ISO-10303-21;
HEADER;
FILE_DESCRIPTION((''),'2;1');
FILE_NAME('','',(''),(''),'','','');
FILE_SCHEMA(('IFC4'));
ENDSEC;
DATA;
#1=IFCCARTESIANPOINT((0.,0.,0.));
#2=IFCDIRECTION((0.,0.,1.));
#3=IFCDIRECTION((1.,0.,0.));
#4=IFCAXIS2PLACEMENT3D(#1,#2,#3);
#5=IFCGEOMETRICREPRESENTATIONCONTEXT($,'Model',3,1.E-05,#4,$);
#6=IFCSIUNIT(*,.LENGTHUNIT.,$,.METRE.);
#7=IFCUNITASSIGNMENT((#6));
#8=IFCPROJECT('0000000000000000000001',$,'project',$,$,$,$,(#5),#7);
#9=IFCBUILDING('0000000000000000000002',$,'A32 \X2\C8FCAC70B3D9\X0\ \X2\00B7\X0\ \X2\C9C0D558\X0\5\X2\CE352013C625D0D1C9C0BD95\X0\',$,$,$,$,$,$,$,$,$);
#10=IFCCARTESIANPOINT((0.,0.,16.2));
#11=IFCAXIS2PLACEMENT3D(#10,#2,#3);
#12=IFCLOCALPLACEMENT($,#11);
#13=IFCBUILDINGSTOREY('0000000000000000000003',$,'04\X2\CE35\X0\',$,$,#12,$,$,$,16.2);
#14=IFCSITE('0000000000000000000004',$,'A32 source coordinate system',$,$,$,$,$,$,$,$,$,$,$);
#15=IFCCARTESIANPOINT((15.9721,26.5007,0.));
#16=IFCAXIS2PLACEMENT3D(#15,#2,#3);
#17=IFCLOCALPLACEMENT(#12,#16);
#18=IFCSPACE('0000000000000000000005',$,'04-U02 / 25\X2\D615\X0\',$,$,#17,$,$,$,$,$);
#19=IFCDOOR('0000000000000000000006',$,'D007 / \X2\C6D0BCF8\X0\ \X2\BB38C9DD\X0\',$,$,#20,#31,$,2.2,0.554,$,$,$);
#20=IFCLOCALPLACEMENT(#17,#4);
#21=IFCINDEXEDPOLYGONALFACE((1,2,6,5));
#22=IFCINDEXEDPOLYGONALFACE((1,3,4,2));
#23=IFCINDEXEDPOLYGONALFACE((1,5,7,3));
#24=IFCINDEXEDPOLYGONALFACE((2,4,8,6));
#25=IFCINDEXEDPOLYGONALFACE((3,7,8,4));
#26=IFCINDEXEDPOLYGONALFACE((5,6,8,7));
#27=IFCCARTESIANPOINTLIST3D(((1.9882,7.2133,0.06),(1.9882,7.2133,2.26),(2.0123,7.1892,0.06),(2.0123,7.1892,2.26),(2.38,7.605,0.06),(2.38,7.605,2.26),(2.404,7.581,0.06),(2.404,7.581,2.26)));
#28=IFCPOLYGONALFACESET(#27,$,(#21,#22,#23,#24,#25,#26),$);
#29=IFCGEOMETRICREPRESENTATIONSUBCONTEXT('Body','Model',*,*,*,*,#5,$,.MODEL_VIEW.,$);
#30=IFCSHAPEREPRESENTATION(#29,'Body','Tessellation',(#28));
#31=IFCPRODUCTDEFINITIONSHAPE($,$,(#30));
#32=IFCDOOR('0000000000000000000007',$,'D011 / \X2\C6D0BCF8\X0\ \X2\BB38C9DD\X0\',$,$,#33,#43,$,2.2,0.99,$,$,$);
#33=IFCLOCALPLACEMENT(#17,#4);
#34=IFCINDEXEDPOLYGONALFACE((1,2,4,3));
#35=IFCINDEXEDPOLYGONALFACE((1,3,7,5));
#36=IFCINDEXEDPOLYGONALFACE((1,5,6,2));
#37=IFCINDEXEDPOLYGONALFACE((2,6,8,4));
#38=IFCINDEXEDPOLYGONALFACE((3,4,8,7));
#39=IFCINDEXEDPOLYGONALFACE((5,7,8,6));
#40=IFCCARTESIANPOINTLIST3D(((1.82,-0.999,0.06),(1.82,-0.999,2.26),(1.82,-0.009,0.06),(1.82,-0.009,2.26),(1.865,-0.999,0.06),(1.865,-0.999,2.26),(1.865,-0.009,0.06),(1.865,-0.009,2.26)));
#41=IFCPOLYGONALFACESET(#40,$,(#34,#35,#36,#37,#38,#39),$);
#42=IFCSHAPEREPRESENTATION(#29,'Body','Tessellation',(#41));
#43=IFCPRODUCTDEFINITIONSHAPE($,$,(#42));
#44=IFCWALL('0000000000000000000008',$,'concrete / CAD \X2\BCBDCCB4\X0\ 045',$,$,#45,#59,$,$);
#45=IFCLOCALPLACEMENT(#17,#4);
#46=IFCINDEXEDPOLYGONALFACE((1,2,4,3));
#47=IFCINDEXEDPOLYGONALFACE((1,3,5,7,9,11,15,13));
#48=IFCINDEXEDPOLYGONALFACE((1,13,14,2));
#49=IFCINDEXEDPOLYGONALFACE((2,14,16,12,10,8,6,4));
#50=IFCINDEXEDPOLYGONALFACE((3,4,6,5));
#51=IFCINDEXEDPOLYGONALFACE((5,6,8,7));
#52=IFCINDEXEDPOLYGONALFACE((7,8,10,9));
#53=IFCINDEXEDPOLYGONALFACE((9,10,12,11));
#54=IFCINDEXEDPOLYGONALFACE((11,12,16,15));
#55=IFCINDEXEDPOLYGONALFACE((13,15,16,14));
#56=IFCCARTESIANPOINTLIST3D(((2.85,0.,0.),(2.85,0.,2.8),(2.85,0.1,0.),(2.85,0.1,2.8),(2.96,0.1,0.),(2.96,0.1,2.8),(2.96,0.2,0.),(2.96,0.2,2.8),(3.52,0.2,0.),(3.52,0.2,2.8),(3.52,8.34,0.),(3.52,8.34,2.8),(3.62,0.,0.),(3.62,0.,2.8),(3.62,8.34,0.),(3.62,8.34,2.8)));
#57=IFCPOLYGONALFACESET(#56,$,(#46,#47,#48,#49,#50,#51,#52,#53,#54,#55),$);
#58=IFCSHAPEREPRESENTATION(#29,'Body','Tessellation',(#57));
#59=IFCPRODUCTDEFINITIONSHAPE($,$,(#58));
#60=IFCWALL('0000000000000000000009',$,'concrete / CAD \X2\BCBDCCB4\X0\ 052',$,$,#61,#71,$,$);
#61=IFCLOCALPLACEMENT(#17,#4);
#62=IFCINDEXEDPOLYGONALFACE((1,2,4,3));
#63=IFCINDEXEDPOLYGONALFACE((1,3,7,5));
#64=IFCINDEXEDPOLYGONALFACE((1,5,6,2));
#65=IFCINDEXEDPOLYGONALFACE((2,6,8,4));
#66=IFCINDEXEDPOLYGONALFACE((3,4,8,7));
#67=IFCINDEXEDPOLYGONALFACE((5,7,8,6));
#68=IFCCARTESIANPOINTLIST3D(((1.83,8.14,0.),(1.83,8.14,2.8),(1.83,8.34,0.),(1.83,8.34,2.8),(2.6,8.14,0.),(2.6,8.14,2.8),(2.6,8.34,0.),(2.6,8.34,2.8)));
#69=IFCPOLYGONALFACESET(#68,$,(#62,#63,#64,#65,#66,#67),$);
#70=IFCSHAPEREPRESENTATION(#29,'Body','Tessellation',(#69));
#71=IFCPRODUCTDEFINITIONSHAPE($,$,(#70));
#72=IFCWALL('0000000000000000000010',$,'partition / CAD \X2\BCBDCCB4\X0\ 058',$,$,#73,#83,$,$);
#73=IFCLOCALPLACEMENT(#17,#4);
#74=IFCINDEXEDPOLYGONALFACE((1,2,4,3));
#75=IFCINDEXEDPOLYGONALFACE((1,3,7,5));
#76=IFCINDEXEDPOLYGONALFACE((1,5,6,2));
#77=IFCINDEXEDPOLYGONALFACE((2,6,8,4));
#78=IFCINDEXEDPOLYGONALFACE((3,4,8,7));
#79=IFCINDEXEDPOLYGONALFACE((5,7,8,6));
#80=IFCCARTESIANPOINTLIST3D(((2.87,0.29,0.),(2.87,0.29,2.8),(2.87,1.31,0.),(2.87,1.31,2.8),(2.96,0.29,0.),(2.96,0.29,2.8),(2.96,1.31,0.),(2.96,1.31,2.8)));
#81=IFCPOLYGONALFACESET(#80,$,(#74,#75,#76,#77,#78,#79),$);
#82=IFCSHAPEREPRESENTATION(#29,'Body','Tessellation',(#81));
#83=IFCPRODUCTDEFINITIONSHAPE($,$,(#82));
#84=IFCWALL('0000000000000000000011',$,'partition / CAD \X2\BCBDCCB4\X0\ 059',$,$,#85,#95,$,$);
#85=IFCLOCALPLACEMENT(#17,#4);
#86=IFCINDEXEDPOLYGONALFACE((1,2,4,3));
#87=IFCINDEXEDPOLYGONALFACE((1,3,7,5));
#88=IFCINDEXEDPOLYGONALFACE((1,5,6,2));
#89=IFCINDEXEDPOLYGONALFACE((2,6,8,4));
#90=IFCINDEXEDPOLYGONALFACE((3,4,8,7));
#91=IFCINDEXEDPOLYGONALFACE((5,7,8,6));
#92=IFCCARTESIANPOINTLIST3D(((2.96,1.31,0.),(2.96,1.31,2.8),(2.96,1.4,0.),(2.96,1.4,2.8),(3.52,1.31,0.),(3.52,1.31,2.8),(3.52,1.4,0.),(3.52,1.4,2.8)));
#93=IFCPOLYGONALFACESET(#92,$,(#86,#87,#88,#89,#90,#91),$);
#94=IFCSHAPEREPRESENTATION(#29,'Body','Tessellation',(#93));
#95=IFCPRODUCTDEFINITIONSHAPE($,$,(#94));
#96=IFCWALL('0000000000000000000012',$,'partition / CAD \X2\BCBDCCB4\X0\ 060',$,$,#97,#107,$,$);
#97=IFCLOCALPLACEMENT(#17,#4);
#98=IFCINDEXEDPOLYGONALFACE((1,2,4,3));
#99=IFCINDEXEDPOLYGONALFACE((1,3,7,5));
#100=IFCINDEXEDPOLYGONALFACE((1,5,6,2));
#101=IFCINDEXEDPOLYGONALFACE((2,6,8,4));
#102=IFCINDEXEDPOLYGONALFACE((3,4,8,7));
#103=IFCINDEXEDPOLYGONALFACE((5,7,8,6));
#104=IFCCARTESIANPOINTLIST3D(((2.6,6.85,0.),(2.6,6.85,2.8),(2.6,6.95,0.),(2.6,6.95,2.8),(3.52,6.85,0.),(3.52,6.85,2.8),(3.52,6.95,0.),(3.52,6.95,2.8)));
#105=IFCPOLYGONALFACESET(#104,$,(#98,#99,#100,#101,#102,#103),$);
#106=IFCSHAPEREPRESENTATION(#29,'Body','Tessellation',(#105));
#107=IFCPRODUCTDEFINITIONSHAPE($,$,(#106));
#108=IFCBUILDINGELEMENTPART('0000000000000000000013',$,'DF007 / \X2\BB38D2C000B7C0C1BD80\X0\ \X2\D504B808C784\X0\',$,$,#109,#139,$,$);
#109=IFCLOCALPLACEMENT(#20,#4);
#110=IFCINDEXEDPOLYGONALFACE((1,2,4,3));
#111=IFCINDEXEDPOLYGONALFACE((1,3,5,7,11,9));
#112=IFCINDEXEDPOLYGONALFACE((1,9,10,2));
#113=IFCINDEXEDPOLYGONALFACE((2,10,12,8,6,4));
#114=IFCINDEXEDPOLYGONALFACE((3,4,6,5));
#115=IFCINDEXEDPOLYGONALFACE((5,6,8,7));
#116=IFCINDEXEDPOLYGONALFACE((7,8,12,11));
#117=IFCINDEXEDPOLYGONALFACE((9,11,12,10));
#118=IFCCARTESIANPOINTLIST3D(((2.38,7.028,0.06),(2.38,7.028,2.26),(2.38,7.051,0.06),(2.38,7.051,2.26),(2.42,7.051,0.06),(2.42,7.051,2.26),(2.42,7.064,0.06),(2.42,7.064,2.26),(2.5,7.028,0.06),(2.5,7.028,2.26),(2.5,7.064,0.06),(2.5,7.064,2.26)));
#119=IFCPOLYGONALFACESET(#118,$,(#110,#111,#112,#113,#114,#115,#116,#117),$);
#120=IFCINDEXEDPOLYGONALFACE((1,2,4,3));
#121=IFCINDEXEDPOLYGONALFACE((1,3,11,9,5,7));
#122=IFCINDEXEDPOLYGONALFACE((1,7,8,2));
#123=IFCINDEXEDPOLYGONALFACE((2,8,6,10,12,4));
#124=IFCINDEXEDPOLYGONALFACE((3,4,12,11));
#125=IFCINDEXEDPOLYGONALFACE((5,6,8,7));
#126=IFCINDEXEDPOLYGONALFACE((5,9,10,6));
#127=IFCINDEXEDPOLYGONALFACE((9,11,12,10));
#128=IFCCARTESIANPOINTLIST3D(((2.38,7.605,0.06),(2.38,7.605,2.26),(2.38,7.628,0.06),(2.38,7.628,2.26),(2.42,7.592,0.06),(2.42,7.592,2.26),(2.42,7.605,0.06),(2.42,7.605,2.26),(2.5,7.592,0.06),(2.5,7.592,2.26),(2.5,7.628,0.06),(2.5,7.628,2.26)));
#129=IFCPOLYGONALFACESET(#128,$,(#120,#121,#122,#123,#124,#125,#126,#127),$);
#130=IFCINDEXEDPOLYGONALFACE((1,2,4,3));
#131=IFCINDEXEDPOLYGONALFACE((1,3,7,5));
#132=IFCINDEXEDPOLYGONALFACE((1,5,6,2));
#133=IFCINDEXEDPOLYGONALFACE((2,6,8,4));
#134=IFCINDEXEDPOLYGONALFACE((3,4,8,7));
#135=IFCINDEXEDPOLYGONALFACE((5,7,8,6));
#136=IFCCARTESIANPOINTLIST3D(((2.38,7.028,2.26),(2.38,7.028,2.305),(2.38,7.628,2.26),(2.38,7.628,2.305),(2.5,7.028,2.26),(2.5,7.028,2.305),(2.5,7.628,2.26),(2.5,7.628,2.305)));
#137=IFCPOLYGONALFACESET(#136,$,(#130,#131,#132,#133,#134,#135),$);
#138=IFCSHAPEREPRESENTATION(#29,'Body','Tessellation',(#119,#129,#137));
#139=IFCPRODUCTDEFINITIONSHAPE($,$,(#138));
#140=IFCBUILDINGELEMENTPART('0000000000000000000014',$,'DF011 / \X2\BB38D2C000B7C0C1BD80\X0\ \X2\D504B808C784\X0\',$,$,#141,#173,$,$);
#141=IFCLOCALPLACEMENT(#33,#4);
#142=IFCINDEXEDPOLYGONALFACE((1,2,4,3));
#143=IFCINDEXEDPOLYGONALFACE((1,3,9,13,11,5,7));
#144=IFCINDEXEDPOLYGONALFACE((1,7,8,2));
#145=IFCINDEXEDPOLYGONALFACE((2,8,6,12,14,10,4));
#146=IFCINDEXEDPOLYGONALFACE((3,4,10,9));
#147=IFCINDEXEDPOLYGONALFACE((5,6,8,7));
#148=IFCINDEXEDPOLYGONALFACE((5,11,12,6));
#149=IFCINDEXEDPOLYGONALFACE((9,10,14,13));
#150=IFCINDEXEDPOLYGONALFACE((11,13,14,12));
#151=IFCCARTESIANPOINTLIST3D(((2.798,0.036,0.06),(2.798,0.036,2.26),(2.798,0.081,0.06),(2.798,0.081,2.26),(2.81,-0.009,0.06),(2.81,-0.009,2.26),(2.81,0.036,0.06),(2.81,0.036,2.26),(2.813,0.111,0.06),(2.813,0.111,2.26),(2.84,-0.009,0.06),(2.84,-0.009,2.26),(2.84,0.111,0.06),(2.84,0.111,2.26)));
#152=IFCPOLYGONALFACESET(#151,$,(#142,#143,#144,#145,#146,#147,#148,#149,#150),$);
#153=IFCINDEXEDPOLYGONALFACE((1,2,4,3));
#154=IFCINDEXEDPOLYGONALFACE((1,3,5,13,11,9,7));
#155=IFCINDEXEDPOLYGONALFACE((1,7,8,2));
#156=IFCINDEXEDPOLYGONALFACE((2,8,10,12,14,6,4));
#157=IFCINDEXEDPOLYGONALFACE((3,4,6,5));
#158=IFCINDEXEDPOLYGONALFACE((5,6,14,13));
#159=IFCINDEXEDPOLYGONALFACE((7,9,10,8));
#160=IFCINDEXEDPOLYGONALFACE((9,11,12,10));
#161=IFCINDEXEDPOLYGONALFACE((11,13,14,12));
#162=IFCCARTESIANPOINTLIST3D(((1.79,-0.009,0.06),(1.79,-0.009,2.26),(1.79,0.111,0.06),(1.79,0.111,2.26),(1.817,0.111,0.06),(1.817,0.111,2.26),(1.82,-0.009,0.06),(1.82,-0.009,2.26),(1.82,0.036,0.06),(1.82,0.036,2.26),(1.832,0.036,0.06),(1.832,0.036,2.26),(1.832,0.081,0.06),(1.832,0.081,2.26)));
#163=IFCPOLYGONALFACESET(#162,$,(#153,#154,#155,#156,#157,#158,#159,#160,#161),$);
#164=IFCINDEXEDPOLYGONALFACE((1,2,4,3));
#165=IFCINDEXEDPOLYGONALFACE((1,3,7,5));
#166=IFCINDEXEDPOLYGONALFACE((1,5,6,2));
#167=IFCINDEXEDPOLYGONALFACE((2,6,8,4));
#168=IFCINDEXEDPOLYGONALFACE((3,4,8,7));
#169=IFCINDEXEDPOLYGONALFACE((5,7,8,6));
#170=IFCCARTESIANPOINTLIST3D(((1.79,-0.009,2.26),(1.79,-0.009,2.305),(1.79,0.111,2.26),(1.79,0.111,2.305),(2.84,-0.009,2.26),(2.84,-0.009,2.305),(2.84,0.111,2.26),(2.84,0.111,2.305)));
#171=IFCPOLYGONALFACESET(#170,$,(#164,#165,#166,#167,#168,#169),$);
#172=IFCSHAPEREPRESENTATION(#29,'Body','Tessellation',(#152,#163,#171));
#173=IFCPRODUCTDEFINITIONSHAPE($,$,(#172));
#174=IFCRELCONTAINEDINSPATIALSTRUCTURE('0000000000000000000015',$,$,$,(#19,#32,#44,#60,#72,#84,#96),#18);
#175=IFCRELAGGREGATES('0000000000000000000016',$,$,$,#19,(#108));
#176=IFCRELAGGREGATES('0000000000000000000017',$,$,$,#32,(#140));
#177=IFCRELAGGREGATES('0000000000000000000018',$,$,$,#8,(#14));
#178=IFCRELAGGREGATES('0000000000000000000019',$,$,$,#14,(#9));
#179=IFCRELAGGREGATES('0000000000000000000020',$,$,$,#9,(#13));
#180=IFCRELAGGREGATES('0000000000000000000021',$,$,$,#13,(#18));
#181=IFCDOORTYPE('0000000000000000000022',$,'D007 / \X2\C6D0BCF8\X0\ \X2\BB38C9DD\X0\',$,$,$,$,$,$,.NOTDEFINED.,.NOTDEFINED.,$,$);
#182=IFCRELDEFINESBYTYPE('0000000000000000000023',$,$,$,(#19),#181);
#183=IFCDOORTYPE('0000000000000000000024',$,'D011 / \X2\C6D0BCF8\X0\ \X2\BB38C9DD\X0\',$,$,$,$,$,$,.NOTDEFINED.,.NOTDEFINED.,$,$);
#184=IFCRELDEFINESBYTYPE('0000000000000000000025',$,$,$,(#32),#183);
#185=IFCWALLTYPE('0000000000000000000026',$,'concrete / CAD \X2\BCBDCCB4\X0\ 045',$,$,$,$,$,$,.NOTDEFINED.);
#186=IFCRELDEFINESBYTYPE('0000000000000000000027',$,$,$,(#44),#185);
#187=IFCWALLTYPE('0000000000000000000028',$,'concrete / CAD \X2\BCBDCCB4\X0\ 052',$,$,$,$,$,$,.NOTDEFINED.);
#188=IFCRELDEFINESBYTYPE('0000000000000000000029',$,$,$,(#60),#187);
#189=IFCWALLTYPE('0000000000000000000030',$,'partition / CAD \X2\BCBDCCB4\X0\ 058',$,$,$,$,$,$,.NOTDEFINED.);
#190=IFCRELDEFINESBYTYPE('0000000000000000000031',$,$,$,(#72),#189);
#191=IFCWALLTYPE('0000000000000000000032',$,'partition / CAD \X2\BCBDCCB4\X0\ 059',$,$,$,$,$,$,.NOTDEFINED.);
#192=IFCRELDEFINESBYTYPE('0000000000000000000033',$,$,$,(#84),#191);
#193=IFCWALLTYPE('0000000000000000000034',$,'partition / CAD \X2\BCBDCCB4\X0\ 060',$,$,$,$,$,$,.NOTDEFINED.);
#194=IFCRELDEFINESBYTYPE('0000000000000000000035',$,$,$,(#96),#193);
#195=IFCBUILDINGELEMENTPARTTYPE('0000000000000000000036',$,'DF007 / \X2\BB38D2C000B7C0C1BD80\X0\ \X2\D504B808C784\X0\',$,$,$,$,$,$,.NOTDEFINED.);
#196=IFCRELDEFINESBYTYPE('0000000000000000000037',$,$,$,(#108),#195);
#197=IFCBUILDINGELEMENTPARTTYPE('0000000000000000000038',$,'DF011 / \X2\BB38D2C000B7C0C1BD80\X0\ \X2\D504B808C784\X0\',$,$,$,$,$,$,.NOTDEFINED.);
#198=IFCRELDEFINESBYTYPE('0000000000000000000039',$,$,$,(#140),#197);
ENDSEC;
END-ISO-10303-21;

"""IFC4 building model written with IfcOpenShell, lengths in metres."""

from ifc_helpers import new_model, si_unit, frame, origin, origin_with_axes, place, context, subcontext, project, spatial, polyline, outline, extrude, source, transform, mapped, type_object, type_shapes, element, aggregate, save


model = new_model("IFC4")

# Units and contexts
model_context = context("Model", 3, precision=1e-05, world=origin_with_axes())
body_context = subcontext(model_context, "Body", "Model", "MODEL_VIEW")
ifc_project = project(units=[si_unit("LENGTHUNIT", "METRE")], contexts=[model_context])

# Site, building, storey, space
storey_placement = place(None, frame((0.0, 0.0, 16.2), z_axis=(0.0, 0.0, 1.0), x_axis=(1.0, 0.0, 0.0)))
space_placement = place(storey_placement, frame((15.9721, 26.5007, 0.0), z_axis=(0.0, 0.0, 1.0), x_axis=(1.0, 0.0, 0.0)))
site = spatial("IfcSite", under=ifc_project, Name="A32 source coordinate system")
building = spatial("IfcBuilding", under=site, Name="A32 주거동 · 지하5층–옥탑지붕")
storey = spatial("IfcBuildingStorey", under=building, at=storey_placement, Name="04층", Elevation=16.2)
space = spatial("IfcSpace", under=storey, at=space_placement, Name="04-U02 / 25형")

# Doors
door_type_1 = type_object("IfcDoorType", Name="D007 / 원본 문짝", OperationType="NOTDEFINED", PredefinedType="NOTDEFINED")
shared_shape_1 = source(origin(), body_context, "Body", "SweptSolid", [
    extrude(outline(polyline([(2.0123, 7.1892), (1.9882, 7.2133), (2.38, 7.605), (2.404, 7.581), (2.0123, 7.1892)])), frame((0.0, 0.0, 0.06)), (0.0, 0.0, 1.0), 2.2),
])
type_shapes(door_type_1, [shared_shape_1])
door_1_placement = place(space_placement, origin_with_axes())
door_1 = element("IfcDoor", 1, at=door_1_placement, inside=space, type_object=door_type_1, Name="D007 / 원본 문짝", OverallHeight=2.2, OverallWidth=0.554, context=body_context, shape_type="MappedRepresentation", body=[
    mapped(shared_shape_1, transform((0.0, 0.0, 0.0), scale=1.0)),
])
door_type_2 = type_object("IfcDoorType", Name="D011 / 원본 문짝", OperationType="NOTDEFINED", PredefinedType="NOTDEFINED")
shared_shape_2 = source(origin(), body_context, "Body", "SweptSolid", [
    extrude(outline(polyline([(1.865, -0.999), (1.82, -0.999), (1.82, -0.009), (1.865, -0.009), (1.865, -0.999)])), frame((0.0, 0.0, 0.06)), (0.0, 0.0, 1.0), 2.2),
])
type_shapes(door_type_2, [shared_shape_2])
door_2_placement = place(space_placement, origin_with_axes())
door_2 = element("IfcDoor", 2, at=door_2_placement, inside=space, type_object=door_type_2, Name="D011 / 원본 문짝", OverallHeight=2.2, OverallWidth=0.99, context=body_context, shape_type="MappedRepresentation", body=[
    mapped(shared_shape_2, transform((0.0, 0.0, 0.0), scale=1.0)),
])

# Walls
wall_type_1 = type_object("IfcWallType", Name="concrete / CAD 벽체 045", PredefinedType="NOTDEFINED")
shared_shape_3 = source(origin(), body_context, "Body", "SweptSolid", [
    extrude(outline(polyline([(2.96, 0.1), (2.96, 0.2), (3.52, 0.2), (3.52, 8.34), (3.72, 8.34), (3.72, 8.34), (3.62, 8.34), (3.62, 0.0), (2.85, 0.0), (2.85, 0.1), (2.96, 0.1)])), origin(), (0.0, 0.0, 1.0), 2.8),
])
type_shapes(wall_type_1, [shared_shape_3])
wall_1_placement = place(space_placement, origin_with_axes())
element("IfcWall", 3, at=wall_1_placement, inside=space, type_object=wall_type_1, Name="concrete / CAD 벽체 045", context=body_context, shape_type="MappedRepresentation", body=[
    mapped(shared_shape_3, transform((0.0, 0.0, 0.0), scale=1.0)),
])
wall_type_2 = type_object("IfcWallType", Name="concrete / CAD 벽체 052", PredefinedType="NOTDEFINED")
shared_shape_4 = source(origin(), body_context, "Body", "SweptSolid", [
    extrude(outline(polyline([(2.6, 8.14), (1.83, 8.14), (1.83, 8.34), (2.6, 8.34), (2.6, 8.14)])), origin(), (0.0, 0.0, 1.0), 2.8),
])
type_shapes(wall_type_2, [shared_shape_4])
wall_2_placement = place(space_placement, origin_with_axes())
element("IfcWall", 4, at=wall_2_placement, inside=space, type_object=wall_type_2, Name="concrete / CAD 벽체 052", context=body_context, shape_type="MappedRepresentation", body=[
    mapped(shared_shape_4, transform((0.0, 0.0, 0.0), scale=1.0)),
])
wall_type_3 = type_object("IfcWallType", Name="partition / CAD 벽체 058", PredefinedType="NOTDEFINED")
shared_shape_5 = source(origin(), body_context, "Body", "SweptSolid", [
    extrude(outline(polyline([(2.96, 1.31), (2.96, 0.29), (2.87, 0.29), (2.87, 1.31), (2.96, 1.31)])), origin(), (0.0, 0.0, 1.0), 2.8),
])
type_shapes(wall_type_3, [shared_shape_5])
wall_3_placement = place(space_placement, origin_with_axes())
element("IfcWall", 5, at=wall_3_placement, inside=space, type_object=wall_type_3, Name="partition / CAD 벽체 058", context=body_context, shape_type="MappedRepresentation", body=[
    mapped(shared_shape_5, transform((0.0, 0.0, 0.0), scale=1.0)),
])
wall_type_4 = type_object("IfcWallType", Name="partition / CAD 벽체 059", PredefinedType="NOTDEFINED")
shared_shape_6 = source(origin(), body_context, "Body", "SweptSolid", [
    extrude(outline(polyline([(3.52, 1.31), (2.96, 1.31), (2.96, 1.4), (3.52, 1.4), (3.52, 1.31)])), origin(), (0.0, 0.0, 1.0), 2.8),
])
type_shapes(wall_type_4, [shared_shape_6])
wall_4_placement = place(space_placement, origin_with_axes())
element("IfcWall", 6, at=wall_4_placement, inside=space, type_object=wall_type_4, Name="partition / CAD 벽체 059", context=body_context, shape_type="MappedRepresentation", body=[
    mapped(shared_shape_6, transform((0.0, 0.0, 0.0), scale=1.0)),
])
wall_type_5 = type_object("IfcWallType", Name="partition / CAD 벽체 060", PredefinedType="NOTDEFINED")
shared_shape_7 = source(origin(), body_context, "Body", "SweptSolid", [
    extrude(outline(polyline([(3.52, 6.85), (2.6, 6.85), (2.6, 6.95), (3.52, 6.95), (3.52, 6.85)])), origin(), (0.0, 0.0, 1.0), 2.8),
])
type_shapes(wall_type_5, [shared_shape_7])
wall_5_placement = place(space_placement, origin_with_axes())
element("IfcWall", 7, at=wall_5_placement, inside=space, type_object=wall_type_5, Name="partition / CAD 벽체 060", context=body_context, shape_type="MappedRepresentation", body=[
    mapped(shared_shape_7, transform((0.0, 0.0, 0.0), scale=1.0)),
])

# Building element parts
building_element_part_type_1 = type_object("IfcBuildingElementPartType", Name="DF007 / 문틀·상부 프레임", PredefinedType="NOTDEFINED")
shared_shape_8 = source(origin(), body_context, "Body", "SweptSolid", [
    extrude(outline(polyline([(2.38, 7.028), (2.38, 7.051), (2.42, 7.051), (2.42, 7.064), (2.5, 7.064), (2.5, 7.028), (2.38, 7.028)])), frame((0.0, 0.0, 0.06)), (0.0, 0.0, 1.0), 2.2),
    extrude(outline(polyline([(2.5, 7.592), (2.42, 7.592), (2.42, 7.605), (2.38, 7.605), (2.38, 7.628), (2.5, 7.628), (2.5, 7.592)])), frame((0.0, 0.0, 0.06)), (0.0, 0.0, 1.0), 2.2),
    extrude(outline(polyline([(2.38, 7.028), (2.38, 7.628), (2.5, 7.628), (2.5, 7.028), (2.38, 7.028)])), frame((0.0, 0.0, 2.26)), (0.0, 0.0, 1.0), 0.045),
])
type_shapes(building_element_part_type_1, [shared_shape_8])
building_element_part_1_placement = place(door_1_placement, origin_with_axes())
building_element_part_1 = element("IfcBuildingElementPart", 8, at=building_element_part_1_placement, type_object=building_element_part_type_1, Name="DF007 / 문틀·상부 프레임", context=body_context, shape_type="MappedRepresentation", body=[
    mapped(shared_shape_8, transform((0.0, 0.0, 0.0), scale=1.0)),
])
aggregate(door_1, [building_element_part_1])
building_element_part_type_2 = type_object("IfcBuildingElementPartType", Name="DF011 / 문틀·상부 프레임", PredefinedType="NOTDEFINED")
shared_shape_9 = source(origin(), body_context, "Body", "SweptSolid", [
    extrude(outline(polyline([(2.81, -0.009), (2.81, 0.036), (2.798, 0.036), (2.798, 0.081), (2.813, 0.111), (2.84, 0.111), (2.84, -0.009), (2.81, -0.009)])), frame((0.0, 0.0, 0.06)), (0.0, 0.0, 1.0), 2.2),
    extrude(outline(polyline([(1.79, 0.111), (1.817, 0.111), (1.832, 0.081), (1.832, 0.036), (1.82, 0.036), (1.82, -0.009), (1.79, -0.009), (1.79, 0.111)])), frame((0.0, 0.0, 0.06)), (0.0, 0.0, 1.0), 2.2),
    extrude(outline(polyline([(1.79, -0.009), (1.79, 0.111), (2.84, 0.111), (2.84, -0.009), (1.79, -0.009)])), frame((0.0, 0.0, 2.26)), (0.0, 0.0, 1.0), 0.045),
])
type_shapes(building_element_part_type_2, [shared_shape_9])
building_element_part_2_placement = place(door_2_placement, origin_with_axes())
building_element_part_2 = element("IfcBuildingElementPart", 9, at=building_element_part_2_placement, type_object=building_element_part_type_2, Name="DF011 / 문틀·상부 프레임", context=body_context, shape_type="MappedRepresentation", body=[
    mapped(shared_shape_9, transform((0.0, 0.0, 0.0), scale=1.0)),
])
aggregate(door_2, [building_element_part_2])

save(model, "model.ifc")
